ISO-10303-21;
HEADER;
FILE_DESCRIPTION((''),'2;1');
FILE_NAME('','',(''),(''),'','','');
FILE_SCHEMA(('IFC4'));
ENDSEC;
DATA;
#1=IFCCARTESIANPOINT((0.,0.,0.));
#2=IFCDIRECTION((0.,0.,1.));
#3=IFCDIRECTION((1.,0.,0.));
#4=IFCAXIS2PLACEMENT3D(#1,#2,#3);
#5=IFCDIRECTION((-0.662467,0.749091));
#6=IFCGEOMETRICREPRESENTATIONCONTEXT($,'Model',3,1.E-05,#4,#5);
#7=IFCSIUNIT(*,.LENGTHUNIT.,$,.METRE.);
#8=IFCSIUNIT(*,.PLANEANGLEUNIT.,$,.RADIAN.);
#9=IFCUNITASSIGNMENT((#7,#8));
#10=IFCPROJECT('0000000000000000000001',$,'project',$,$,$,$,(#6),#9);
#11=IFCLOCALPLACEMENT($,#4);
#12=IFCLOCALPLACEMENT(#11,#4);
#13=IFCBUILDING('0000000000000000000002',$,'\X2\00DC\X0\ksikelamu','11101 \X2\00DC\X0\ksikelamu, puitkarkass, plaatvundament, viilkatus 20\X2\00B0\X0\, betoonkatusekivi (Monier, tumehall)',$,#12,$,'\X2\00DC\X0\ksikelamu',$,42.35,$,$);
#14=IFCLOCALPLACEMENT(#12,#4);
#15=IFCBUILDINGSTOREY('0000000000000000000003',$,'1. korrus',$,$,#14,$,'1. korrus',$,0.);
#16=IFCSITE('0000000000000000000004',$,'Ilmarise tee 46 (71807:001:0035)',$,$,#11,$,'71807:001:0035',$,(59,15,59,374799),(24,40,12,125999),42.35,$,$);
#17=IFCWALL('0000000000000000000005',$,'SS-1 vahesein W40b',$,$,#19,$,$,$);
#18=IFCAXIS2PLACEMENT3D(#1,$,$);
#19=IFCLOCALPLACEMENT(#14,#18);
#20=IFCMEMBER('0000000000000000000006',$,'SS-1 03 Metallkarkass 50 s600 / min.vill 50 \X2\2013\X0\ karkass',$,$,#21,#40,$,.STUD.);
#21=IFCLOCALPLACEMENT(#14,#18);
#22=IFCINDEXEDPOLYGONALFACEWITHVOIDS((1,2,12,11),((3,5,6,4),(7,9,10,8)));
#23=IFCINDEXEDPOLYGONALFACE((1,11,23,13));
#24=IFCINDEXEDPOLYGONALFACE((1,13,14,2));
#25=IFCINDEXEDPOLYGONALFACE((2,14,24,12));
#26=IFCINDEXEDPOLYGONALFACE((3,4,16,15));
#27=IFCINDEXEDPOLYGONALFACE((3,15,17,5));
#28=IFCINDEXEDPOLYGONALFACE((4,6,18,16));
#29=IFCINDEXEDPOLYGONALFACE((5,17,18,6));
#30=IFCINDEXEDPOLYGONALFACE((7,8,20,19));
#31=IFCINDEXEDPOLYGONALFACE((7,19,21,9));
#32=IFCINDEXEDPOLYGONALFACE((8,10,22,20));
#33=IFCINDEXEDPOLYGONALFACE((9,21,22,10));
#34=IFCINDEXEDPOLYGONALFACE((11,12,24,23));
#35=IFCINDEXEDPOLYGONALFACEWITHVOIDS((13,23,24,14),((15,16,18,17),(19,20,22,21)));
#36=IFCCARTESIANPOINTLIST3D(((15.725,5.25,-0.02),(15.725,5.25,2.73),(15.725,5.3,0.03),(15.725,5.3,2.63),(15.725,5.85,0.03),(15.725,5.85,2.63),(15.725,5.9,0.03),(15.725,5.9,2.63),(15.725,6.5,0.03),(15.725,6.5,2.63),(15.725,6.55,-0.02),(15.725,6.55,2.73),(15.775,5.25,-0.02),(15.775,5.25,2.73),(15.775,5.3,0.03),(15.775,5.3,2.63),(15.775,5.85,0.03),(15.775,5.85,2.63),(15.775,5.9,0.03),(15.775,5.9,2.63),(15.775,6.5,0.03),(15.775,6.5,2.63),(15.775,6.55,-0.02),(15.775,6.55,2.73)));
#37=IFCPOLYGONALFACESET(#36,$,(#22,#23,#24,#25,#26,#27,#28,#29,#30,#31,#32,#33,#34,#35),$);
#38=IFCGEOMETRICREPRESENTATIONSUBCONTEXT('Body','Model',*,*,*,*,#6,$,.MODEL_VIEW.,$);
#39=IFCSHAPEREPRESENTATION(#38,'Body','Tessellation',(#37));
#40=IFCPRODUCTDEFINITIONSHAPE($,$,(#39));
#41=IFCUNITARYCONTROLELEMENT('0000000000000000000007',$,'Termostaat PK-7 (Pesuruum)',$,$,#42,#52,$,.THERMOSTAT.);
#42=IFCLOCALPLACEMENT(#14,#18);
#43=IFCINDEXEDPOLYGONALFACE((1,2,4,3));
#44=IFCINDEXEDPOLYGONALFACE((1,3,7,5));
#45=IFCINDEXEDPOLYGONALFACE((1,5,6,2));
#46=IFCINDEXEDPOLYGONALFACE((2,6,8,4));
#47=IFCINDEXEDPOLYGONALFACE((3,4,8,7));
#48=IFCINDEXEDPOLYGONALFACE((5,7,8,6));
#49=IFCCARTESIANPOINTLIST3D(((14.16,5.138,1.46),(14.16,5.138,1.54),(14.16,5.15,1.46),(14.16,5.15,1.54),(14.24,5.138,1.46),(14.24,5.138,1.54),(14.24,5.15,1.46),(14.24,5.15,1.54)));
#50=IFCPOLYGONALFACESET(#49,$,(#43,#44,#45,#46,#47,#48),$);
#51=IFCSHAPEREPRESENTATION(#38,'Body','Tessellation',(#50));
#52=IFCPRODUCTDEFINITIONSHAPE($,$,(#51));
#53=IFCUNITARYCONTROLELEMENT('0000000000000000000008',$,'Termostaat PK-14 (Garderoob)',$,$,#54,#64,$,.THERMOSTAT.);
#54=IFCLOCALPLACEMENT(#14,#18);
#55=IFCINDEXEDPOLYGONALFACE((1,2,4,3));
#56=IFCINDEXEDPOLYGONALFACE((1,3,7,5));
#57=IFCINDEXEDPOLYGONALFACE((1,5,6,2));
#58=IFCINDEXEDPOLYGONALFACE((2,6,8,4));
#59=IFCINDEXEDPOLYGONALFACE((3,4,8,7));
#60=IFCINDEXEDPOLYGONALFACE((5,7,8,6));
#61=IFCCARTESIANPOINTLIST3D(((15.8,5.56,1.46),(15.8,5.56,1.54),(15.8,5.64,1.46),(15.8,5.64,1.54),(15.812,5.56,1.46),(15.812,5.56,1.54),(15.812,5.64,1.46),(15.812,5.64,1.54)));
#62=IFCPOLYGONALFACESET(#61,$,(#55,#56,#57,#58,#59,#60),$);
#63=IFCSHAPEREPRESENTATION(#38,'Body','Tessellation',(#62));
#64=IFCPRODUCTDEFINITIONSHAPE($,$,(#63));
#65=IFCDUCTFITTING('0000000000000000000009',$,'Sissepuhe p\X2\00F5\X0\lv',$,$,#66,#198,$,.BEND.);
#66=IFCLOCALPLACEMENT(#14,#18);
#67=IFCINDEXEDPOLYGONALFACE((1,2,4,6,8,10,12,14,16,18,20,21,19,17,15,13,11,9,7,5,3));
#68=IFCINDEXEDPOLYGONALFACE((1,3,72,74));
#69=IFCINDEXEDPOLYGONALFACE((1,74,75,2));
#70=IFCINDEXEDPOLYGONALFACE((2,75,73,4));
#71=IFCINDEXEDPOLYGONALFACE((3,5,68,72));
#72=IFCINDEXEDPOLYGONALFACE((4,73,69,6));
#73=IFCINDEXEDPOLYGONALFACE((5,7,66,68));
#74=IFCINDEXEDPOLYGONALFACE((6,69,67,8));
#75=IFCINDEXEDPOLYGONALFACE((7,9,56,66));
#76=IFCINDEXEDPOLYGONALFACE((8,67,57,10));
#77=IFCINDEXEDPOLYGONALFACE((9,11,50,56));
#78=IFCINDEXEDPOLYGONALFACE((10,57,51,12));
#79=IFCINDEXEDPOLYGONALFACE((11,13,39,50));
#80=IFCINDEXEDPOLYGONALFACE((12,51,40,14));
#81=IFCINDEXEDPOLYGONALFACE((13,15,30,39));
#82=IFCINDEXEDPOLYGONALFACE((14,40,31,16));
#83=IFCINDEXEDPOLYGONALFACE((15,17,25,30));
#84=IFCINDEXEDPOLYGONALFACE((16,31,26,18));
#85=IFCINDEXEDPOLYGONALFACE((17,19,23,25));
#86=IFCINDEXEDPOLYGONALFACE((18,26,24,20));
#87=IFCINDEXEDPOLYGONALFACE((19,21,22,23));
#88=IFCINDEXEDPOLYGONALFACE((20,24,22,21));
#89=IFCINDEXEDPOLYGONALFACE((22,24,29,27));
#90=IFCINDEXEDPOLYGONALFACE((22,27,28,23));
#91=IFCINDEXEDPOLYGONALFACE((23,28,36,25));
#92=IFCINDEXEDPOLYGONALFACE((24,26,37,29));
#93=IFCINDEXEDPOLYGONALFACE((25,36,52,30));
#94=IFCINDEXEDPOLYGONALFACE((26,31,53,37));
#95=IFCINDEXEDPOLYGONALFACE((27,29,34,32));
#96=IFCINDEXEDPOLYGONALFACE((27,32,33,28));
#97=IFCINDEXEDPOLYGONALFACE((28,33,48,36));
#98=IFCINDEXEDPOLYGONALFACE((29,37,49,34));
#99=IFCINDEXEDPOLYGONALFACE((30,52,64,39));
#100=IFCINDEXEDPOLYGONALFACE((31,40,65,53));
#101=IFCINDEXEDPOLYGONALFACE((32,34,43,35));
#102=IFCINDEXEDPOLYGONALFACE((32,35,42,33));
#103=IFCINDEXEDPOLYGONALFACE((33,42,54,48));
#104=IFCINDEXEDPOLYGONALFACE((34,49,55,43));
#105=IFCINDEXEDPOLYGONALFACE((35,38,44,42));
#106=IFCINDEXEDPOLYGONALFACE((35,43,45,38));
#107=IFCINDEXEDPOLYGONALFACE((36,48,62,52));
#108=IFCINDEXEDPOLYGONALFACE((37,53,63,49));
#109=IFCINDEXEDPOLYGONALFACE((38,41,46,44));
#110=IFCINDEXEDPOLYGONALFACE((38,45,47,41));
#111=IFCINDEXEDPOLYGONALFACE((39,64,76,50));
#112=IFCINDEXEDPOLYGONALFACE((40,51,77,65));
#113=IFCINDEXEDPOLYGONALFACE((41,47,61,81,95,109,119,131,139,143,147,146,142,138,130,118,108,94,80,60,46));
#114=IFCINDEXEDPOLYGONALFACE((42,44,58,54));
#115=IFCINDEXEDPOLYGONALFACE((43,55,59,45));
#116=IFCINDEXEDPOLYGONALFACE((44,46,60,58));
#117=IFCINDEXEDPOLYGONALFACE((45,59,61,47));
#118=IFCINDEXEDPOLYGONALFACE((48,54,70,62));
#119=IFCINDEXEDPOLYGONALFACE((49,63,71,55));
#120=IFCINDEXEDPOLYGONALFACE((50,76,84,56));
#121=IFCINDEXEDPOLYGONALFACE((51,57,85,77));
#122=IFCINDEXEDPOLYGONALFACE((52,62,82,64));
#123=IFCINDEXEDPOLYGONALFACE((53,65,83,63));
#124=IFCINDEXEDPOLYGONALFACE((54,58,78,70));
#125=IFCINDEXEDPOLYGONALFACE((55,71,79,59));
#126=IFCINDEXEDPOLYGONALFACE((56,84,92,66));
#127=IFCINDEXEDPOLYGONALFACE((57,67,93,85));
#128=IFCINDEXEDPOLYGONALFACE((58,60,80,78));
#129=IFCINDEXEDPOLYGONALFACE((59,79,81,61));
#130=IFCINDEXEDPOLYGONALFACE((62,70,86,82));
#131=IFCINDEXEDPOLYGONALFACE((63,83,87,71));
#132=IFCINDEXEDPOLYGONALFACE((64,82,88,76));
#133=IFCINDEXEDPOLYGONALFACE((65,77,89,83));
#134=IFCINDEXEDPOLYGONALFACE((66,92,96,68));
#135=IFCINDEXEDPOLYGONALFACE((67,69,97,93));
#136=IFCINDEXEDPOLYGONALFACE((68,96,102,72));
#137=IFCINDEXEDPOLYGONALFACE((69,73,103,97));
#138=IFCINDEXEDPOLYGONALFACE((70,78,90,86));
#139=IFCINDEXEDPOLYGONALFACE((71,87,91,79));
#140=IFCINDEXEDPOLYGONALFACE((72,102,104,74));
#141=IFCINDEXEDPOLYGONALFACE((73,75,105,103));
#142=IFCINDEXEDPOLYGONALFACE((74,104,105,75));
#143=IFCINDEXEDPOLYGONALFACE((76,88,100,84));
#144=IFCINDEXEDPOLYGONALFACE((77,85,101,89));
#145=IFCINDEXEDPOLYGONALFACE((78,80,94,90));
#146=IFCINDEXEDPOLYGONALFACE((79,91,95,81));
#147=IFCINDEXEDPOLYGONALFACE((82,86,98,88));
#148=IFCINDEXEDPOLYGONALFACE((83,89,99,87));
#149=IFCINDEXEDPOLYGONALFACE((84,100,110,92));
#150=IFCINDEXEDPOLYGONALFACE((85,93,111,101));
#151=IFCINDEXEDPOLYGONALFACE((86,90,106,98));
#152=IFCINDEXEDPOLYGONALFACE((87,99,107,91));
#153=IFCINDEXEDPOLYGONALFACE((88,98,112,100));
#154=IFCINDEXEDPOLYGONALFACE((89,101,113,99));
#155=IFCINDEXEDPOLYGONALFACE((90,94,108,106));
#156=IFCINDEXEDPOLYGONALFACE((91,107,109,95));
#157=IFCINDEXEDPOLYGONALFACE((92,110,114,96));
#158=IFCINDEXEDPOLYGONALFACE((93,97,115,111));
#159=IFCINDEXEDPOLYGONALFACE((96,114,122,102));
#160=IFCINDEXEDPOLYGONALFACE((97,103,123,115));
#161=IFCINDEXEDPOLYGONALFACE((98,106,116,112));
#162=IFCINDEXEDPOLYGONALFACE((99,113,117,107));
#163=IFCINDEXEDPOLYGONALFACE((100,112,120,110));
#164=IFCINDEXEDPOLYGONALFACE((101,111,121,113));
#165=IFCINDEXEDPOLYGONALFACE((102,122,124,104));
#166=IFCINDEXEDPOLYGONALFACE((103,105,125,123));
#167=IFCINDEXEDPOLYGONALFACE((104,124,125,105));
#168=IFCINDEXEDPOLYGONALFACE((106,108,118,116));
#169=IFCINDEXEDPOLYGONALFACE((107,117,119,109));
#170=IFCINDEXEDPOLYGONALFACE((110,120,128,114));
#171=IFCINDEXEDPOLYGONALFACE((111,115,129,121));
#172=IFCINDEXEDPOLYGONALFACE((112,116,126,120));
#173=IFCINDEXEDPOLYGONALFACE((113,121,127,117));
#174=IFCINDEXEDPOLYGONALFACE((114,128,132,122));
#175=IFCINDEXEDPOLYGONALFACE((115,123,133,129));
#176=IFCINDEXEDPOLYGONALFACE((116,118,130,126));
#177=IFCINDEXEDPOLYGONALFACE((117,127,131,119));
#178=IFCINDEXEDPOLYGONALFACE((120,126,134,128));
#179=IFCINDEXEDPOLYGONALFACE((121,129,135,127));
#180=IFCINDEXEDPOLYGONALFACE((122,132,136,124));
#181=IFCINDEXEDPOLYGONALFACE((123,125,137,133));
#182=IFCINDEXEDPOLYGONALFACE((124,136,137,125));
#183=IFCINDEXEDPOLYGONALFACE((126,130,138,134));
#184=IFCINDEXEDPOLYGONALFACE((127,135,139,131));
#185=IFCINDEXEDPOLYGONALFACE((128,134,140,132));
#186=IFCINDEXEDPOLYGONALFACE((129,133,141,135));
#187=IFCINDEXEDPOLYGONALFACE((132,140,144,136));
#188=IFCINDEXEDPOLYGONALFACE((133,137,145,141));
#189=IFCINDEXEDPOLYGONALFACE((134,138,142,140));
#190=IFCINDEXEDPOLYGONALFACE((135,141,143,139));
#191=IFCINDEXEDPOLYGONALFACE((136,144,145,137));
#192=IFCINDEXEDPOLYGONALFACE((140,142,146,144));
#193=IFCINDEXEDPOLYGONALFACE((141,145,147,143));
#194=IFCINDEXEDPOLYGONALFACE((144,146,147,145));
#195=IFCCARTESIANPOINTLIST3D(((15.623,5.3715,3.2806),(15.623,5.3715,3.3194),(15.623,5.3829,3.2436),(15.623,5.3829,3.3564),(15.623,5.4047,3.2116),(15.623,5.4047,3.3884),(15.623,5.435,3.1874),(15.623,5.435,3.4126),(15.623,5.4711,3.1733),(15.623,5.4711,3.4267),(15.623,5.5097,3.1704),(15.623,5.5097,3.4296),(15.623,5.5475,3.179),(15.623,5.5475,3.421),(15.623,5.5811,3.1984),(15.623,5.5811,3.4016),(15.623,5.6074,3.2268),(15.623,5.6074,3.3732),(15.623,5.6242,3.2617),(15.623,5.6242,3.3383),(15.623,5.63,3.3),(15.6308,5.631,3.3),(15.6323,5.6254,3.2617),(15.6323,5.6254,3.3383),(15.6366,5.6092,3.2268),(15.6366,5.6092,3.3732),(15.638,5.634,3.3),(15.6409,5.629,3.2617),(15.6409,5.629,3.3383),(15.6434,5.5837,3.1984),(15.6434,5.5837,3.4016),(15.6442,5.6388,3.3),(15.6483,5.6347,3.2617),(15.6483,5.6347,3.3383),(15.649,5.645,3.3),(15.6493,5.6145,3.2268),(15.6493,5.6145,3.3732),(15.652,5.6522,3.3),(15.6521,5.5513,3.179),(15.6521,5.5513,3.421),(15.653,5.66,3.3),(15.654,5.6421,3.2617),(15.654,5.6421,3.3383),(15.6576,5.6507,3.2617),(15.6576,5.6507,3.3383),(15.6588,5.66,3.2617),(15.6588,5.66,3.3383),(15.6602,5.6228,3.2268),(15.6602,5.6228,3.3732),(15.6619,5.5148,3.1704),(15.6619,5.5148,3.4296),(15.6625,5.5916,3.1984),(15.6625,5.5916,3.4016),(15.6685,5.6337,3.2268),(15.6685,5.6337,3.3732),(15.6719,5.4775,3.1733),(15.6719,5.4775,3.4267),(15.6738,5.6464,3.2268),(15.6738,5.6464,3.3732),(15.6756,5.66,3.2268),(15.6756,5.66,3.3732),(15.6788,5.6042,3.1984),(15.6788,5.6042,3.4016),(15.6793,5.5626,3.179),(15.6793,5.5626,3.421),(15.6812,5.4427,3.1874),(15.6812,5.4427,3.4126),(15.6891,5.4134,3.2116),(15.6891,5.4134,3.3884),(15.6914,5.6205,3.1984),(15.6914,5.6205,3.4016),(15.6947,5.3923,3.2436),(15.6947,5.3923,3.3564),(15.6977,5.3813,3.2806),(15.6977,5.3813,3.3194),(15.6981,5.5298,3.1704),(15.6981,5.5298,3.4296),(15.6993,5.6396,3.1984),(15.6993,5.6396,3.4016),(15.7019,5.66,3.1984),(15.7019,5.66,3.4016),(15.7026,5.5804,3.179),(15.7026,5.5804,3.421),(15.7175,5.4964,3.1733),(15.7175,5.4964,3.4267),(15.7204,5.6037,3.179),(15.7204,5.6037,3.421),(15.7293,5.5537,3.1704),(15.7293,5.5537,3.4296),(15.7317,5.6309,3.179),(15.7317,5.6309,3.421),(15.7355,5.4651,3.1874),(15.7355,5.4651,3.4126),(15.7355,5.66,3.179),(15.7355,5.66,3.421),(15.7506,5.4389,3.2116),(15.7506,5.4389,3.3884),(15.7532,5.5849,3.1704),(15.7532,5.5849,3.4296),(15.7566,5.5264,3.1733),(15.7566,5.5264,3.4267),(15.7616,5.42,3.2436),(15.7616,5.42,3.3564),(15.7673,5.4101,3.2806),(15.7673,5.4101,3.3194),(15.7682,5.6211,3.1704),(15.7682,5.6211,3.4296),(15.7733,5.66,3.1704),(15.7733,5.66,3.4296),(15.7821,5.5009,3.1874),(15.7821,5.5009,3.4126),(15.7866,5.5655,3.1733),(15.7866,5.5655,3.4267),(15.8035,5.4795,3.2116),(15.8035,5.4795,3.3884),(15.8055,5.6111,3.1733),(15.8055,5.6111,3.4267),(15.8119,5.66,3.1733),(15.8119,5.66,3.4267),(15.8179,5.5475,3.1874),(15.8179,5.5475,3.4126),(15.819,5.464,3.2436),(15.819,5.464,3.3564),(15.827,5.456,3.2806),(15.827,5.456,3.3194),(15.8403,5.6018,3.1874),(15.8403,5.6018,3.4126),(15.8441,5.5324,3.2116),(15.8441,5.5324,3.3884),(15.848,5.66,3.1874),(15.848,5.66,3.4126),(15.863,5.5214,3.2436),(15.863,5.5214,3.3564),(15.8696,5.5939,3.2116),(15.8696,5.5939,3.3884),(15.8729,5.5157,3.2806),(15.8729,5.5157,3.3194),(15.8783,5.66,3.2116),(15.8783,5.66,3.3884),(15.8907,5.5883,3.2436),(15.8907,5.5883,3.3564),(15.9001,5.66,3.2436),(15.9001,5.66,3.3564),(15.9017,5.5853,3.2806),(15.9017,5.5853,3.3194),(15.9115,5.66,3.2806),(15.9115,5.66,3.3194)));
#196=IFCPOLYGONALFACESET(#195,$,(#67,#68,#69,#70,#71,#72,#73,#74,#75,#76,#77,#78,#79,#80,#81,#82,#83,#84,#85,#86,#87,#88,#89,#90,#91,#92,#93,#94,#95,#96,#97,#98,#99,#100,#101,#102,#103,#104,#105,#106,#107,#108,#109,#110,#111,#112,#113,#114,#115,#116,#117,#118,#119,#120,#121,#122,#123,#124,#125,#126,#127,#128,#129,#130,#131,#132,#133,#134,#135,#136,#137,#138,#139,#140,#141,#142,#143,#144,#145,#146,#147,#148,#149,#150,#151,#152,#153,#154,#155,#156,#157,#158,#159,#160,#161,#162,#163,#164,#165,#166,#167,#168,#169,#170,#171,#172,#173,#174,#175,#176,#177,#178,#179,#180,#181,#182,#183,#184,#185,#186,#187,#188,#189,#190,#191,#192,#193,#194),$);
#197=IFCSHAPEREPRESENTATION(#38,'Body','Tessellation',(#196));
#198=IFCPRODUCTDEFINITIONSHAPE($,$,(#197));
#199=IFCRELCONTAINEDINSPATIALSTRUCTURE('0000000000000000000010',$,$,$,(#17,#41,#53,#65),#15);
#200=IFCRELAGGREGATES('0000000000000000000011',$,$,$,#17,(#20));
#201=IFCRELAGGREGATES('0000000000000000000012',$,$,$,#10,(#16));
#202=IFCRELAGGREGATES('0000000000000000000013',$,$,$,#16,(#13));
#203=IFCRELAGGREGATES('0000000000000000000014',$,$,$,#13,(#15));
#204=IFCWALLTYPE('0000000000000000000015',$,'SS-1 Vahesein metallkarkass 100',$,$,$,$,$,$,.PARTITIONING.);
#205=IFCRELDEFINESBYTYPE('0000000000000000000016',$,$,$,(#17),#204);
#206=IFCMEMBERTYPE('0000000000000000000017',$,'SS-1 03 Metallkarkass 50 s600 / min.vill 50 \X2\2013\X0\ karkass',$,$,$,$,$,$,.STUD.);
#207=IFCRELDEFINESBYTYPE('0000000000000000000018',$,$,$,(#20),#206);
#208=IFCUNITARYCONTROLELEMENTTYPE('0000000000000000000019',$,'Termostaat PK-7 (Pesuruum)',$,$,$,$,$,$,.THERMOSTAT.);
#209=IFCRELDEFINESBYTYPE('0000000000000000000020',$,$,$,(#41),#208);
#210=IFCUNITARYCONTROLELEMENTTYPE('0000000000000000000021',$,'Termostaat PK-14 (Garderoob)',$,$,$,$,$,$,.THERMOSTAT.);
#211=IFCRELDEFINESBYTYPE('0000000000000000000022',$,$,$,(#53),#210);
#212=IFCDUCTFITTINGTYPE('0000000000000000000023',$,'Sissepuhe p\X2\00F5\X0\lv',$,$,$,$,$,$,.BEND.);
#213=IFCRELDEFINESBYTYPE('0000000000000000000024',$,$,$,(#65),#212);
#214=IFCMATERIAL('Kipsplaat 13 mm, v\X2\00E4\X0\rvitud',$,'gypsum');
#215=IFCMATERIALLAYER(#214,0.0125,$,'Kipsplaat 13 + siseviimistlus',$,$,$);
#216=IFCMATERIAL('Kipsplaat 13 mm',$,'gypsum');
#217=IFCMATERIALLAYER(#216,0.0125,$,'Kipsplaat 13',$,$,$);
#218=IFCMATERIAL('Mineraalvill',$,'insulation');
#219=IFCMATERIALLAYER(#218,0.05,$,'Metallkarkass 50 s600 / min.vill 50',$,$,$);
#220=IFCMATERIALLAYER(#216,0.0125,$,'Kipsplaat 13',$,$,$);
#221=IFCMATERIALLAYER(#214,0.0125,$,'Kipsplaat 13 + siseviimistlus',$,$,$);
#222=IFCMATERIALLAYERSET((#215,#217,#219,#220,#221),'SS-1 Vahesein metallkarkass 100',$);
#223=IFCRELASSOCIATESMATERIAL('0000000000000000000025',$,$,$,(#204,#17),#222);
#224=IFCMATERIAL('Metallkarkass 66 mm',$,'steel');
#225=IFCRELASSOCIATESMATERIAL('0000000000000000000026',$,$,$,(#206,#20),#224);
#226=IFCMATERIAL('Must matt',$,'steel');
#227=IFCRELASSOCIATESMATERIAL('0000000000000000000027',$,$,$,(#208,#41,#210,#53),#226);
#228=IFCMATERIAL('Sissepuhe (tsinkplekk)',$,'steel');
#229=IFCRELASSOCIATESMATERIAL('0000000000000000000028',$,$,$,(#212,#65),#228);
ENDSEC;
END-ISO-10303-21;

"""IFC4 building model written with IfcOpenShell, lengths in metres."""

from ifc_helpers import new_model, entity, si_unit, direction, frame, origin_with_axes, place, context, subcontext, project, spatial, indexed_curve, outline, extrude, material, layer, layer_set, layer_usage, type_object, element, aggregate, save


model = new_model("IFC4")

# Units and contexts
model_context = context("Model", 3, precision=1e-05, world=origin_with_axes(), true_north=direction((-0.662467, 0.749091)))
body_context = subcontext(model_context, "Body", "Model", "MODEL_VIEW")
ifc_project = project(units=[si_unit("LENGTHUNIT", "METRE"), si_unit("PLANEANGLEUNIT", "RADIAN")], contexts=[model_context])

# Site, building, storey
site_placement = place(None, origin_with_axes())
site = spatial("IfcSite", under=ifc_project, at=site_placement, Name="Ilmarise tee 46 (71807:001:0035)", LongName="71807:001:0035", RefLatitude=(59, 15, 59, 374799), RefLongitude=(24, 40, 12, 125999), RefElevation=42.35)
building_placement = place(site_placement, origin_with_axes())
building = spatial("IfcBuilding", under=site, at=building_placement, Name="Üksikelamu", Description="11101 Üksikelamu, puitkarkass, plaatvundament, viilkatus 20°, betoonkatusekivi (Monier, tumehall)", LongName="Üksikelamu", ElevationOfRefHeight=42.35)
storey_placement = place(building_placement, origin_with_axes())
storey = spatial("IfcBuildingStorey", under=building, at=storey_placement, Name="1. korrus", LongName="1. korrus", Elevation=0.0)

# Wall, member
ifc_material_1 = material(Name="Kipsplaat 13 mm, värvitud", Category="gypsum")
ifc_layer_1 = layer(ifc_material_1, 0.0125, Name="Kipsplaat 13 + siseviimistlus")
ifc_material_2 = material(Name="Kipsplaat 13 mm", Category="gypsum")
ifc_layer_2 = layer(ifc_material_2, 0.0125, Name="Kipsplaat 13")
ifc_material_3 = material(Name="Mineraalvill", Category="insulation")
ifc_layer_3 = layer(ifc_material_3, 0.05, Name="Metallkarkass 50 s600 / min.vill 50")
ifc_layer_4 = layer(ifc_material_2, 0.0125, Name="Kipsplaat 13")
ifc_layer_5 = layer(ifc_material_1, 0.0125, Name="Kipsplaat 13 + siseviimistlus")
ifc_layer_set = layer_set([ifc_layer_1, ifc_layer_2, ifc_layer_3, ifc_layer_4, ifc_layer_5], Name="SS-1 Vahesein metallkarkass 100")
ifc_layer_usage = layer_usage(ifc_layer_set, "AXIS2", "NEGATIVE", 0.0)
wall_type = type_object("IfcWallType", Name="SS-1 Vahesein metallkarkass 100", PredefinedType="PARTITIONING", material=ifc_layer_set)
wall_placement = place(storey_placement, frame((15.7, 5.25, 0.0), z_axis=(0.0, 0.0, 1.0), x_axis=(0.0, 1.0, 0.0)))
wall = element("IfcWall", 1, at=wall_placement, inside=storey, type_object=wall_type, material=ifc_layer_usage, Name="SS-1 vahesein W40b")
ifc_material_4 = material(Name="Metallkarkass 66 mm", Category="steel")
member_type = type_object("IfcMemberType", Name="SS-1 03 Metallkarkass 50 s600 / min.vill 50 – karkass", PredefinedType="STUD", material=ifc_material_4)
member_placement = place(wall_placement, origin_with_axes())
member = element("IfcMember", 2, at=member_placement, type_object=member_type, material=ifc_material_4, Name="SS-1 03 Metallkarkass 50 s600 / min.vill 50 – karkass", PredefinedType="STUD", context=body_context, shape_type="SweptSolid", body=[
    extrude(outline(indexed_curve([(1.3, -0.02), (0.0, -0.02), (0.0, 2.73), (1.3, 2.73), (1.3, -0.02)], self_intersect=False), holes=[indexed_curve([(0.6, 0.03), (0.6, 2.63), (0.05, 2.63), (0.05, 0.03), (0.6, 0.03)], self_intersect=False), indexed_curve([(1.25, 2.63), (0.65, 2.63), (0.65, 0.03), (1.25, 0.03), (1.25, 2.63)], self_intersect=False)]), frame((0.0, -0.025, 0.0), z_axis=(0.0, -1.0, 0.0), x_axis=(1.0, 0.0, 0.0)), (0.0, 0.0, 1.0), 0.05),
])

# Unitary control elements
ifc_material_5 = material(Name="Must matt", Category="steel")
unitary_control_element_type_1 = type_object("IfcUnitaryControlElementType", Name="Termostaat PK-7 (Pesuruum)", PredefinedType="THERMOSTAT", material=ifc_material_5)
unitary_control_element_1_placement = place(storey_placement, frame((14.2, 5.138, 0.0), z_axis=(0.0, 0.0, 1.0), x_axis=(-1.0, 0.0, 0.0)))
element("IfcUnitaryControlElement", 3, at=unitary_control_element_1_placement, inside=storey, type_object=unitary_control_element_type_1, material=ifc_material_5, Name="Termostaat PK-7 (Pesuruum)", PredefinedType="THERMOSTAT", context=body_context, shape_type="SweptSolid", body=[
    extrude(outline(indexed_curve([(-0.04, -0.012), (0.04, -0.012), (0.04, 0.0), (-0.04, 0.0), (-0.04, -0.012)], self_intersect=False)), frame((0.0, 0.0, 1.46), z_axis=(0.0, 0.0, 1.0), x_axis=(1.0, 0.0, 0.0)), (0.0, 0.0, 1.0), 0.08),
])
unitary_control_element_type_2 = type_object("IfcUnitaryControlElementType", Name="Termostaat PK-14 (Garderoob)", PredefinedType="THERMOSTAT", material=ifc_material_5)
unitary_control_element_2_placement = place(storey_placement, frame((15.812, 5.6, 0.0), z_axis=(0.0, 0.0, 1.0), x_axis=(0.0, -1.0, 0.0)))
element("IfcUnitaryControlElement", 4, at=unitary_control_element_2_placement, inside=storey, type_object=unitary_control_element_type_2, material=ifc_material_5, Name="Termostaat PK-14 (Garderoob)", PredefinedType="THERMOSTAT", context=body_context, shape_type="SweptSolid", body=[
    extrude(outline(indexed_curve([(-0.04, -0.012), (0.04, -0.012), (0.04, 0.0), (-0.04, 0.0), (-0.04, -0.012)], self_intersect=False)), frame((0.0, 0.0, 1.46), z_axis=(0.0, 0.0, 1.0), x_axis=(1.0, 0.0, 0.0)), (0.0, 0.0, 1.0), 0.08),
])

# Duct fitting
ifc_material_6 = material(Name="Sissepuhe (tsinkplekk)", Category="steel")
duct_fitting_type_1 = type_object("IfcDuctFittingType", Name="Sissepuhe põlv", PredefinedType="BEND", material=ifc_material_6)
duct_fitting_1_placement = place(storey_placement, frame((15.783, 5.5, 3.3), z_axis=(0.0, 0.0, 1.0), x_axis=(1.0, 0.0, 0.0)))
element("IfcDuctFitting", 5, at=duct_fitting_1_placement, inside=storey, type_object=duct_fitting_type_1, material=ifc_material_6, Name="Sissepuhe põlv", PredefinedType="BEND", context=body_context, shape_type="SweptSolid", body=[
    entity("IfcRevolvedAreaSolid", entity("IfcCircleProfileDef", "AREA", None, None, 0.13), entity("IfcAxis2Placement3D", entity("IfcCartesianPoint", [-0.16, 0.0, 0.0]), entity("IfcDirection", [1.0, 0.0, 0.0]), entity("IfcDirection", [0.0, 1.0, 0.0])), entity("IfcAxis1Placement", entity("IfcCartesianPoint", [0.16, 0.0, 0.0]), entity("IfcDirection", [0.0, 1.0, 0.0])), 1.570796),
])

aggregate(wall, [member])

save(model, "model.ifc")
